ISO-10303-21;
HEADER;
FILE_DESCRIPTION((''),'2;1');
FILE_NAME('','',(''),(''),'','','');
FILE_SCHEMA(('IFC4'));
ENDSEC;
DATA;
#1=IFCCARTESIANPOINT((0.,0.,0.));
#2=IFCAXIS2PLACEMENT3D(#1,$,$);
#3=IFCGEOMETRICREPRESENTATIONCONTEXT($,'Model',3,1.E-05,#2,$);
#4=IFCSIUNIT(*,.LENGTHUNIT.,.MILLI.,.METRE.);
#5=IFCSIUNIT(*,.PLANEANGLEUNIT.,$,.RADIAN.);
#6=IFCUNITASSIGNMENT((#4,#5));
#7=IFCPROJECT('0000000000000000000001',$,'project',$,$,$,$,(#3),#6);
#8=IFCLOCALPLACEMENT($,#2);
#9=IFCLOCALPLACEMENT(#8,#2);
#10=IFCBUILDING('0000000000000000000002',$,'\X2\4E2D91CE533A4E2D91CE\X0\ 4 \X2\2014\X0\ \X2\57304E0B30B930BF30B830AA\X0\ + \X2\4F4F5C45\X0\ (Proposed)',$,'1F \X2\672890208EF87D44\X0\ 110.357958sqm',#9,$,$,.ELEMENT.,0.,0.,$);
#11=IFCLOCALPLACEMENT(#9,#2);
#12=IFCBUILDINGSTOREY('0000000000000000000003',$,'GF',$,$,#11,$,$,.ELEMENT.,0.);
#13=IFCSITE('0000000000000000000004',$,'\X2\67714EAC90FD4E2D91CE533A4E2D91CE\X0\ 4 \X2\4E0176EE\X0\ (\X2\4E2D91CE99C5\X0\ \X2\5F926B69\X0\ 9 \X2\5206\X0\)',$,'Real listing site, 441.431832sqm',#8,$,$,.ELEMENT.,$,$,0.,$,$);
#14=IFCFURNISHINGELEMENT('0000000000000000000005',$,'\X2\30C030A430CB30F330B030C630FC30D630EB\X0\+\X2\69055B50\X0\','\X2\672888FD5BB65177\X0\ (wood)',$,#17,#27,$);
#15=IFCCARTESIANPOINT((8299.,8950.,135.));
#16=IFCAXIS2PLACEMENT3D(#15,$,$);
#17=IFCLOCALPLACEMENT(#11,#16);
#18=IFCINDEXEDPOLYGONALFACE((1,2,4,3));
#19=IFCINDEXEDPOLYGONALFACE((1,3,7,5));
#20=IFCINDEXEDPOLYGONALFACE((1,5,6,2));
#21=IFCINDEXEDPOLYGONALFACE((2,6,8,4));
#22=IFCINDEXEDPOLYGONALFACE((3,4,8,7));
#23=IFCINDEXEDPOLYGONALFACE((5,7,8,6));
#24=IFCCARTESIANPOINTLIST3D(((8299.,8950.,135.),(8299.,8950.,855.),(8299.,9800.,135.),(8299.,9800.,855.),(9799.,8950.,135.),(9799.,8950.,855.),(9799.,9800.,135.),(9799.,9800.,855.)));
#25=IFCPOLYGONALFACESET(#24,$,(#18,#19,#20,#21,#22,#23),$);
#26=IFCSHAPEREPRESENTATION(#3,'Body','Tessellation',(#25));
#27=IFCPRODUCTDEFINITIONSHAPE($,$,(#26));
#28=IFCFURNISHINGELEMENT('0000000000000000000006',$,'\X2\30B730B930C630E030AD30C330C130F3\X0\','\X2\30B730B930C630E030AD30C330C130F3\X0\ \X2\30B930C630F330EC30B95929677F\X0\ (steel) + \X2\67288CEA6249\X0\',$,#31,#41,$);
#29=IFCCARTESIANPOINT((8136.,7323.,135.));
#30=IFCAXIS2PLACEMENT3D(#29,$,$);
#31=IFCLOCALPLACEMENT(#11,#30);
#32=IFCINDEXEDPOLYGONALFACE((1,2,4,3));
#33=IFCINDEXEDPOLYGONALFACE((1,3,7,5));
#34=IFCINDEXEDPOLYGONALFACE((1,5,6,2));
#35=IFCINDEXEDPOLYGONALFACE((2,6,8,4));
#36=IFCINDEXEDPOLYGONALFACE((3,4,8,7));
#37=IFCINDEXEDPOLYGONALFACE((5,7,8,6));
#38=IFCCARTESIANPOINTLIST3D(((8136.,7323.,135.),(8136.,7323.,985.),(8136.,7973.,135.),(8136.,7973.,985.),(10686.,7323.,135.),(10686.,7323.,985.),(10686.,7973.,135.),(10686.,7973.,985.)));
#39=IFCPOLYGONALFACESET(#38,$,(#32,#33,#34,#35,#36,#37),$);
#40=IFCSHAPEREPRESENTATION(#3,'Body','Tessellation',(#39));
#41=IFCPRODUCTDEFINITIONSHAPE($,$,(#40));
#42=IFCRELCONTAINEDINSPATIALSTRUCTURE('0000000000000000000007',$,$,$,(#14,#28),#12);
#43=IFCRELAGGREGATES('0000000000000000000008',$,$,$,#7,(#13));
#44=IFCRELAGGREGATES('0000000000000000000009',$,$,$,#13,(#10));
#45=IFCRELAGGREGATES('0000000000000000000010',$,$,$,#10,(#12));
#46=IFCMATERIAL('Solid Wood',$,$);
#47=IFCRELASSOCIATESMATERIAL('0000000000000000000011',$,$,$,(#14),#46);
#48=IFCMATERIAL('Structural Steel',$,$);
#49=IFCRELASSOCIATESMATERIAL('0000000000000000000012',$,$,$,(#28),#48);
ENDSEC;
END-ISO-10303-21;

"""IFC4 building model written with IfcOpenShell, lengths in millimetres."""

from ifc_helpers import new_model, si_unit, frame, frame_2d, origin, place, context, project, spatial, rectangle, extrude, material, element, save


model = new_model("IFC4")

# Units and contexts
model_context = context("Model", 3, precision=1e-05, world=origin())
ifc_project = project(units=[si_unit("LENGTHUNIT", "METRE", prefix="MILLI"), si_unit("PLANEANGLEUNIT", "RADIAN")], contexts=[model_context])

# Site, building, storey
site_placement = place(None, origin())
site = spatial("IfcSite", under=ifc_project, at=site_placement, Name="東京都中野区中野 4 丁目 (中野駅 徒歩 9 分)", ObjectType="Real listing site, 441.431832sqm", CompositionType="ELEMENT", RefElevation=0.0)
building_placement = place(site_placement, origin())
building = spatial("IfcBuilding", under=site, at=building_placement, Name="中野区中野 4 — 地下スタジオ + 住居 (Proposed)", ObjectType="1F 木造軸組 110.357958sqm", CompositionType="ELEMENT", ElevationOfRefHeight=0.0, ElevationOfTerrain=0.0)
storey_placement = place(building_placement, origin())
storey = spatial("IfcBuildingStorey", under=building, at=storey_placement, Name="GF", CompositionType="ELEMENT", Elevation=0.0)

# Shared definitions
ifc_material_1 = material(Name="Solid Wood")

# Shared definitions
ifc_material_2 = material(Name="Structural Steel")

# Furnishing elements
furnishing_1_placement = place(storey_placement, frame((8299.0, 8950.0, 135.0)))
element("IfcFurnishingElement", 1, at=furnishing_1_placement, inside=storey, material=ifc_material_1, Name="ダイニングテーブル+椅子", Description="木製家具 (wood)", context=model_context, shape_type="SweptSolid", body=[
    extrude(rectangle(XDim=1500.0, YDim=850.0, at=frame_2d((750.0, 425.0))), frame((8299.0, 8950.0, 135.0)), (0.0, 0.0, 1.0), 720.0),
])
furnishing_2_placement = place(storey_placement, frame((8136.0, 7323.0, 135.0)))
element("IfcFurnishingElement", 2, at=furnishing_2_placement, inside=storey, material=ifc_material_2, Name="システムキッチン", Description="システムキッチン ステンレス天板 (steel) + 木質扉", context=model_context, shape_type="SweptSolid", body=[
    extrude(rectangle(XDim=2550.0, YDim=650.0, at=frame_2d((1275.0, 325.0))), frame((8136.0, 7323.0, 135.0)), (0.0, 0.0, 1.0), 850.0),
])

save(model, "model.ifc")
